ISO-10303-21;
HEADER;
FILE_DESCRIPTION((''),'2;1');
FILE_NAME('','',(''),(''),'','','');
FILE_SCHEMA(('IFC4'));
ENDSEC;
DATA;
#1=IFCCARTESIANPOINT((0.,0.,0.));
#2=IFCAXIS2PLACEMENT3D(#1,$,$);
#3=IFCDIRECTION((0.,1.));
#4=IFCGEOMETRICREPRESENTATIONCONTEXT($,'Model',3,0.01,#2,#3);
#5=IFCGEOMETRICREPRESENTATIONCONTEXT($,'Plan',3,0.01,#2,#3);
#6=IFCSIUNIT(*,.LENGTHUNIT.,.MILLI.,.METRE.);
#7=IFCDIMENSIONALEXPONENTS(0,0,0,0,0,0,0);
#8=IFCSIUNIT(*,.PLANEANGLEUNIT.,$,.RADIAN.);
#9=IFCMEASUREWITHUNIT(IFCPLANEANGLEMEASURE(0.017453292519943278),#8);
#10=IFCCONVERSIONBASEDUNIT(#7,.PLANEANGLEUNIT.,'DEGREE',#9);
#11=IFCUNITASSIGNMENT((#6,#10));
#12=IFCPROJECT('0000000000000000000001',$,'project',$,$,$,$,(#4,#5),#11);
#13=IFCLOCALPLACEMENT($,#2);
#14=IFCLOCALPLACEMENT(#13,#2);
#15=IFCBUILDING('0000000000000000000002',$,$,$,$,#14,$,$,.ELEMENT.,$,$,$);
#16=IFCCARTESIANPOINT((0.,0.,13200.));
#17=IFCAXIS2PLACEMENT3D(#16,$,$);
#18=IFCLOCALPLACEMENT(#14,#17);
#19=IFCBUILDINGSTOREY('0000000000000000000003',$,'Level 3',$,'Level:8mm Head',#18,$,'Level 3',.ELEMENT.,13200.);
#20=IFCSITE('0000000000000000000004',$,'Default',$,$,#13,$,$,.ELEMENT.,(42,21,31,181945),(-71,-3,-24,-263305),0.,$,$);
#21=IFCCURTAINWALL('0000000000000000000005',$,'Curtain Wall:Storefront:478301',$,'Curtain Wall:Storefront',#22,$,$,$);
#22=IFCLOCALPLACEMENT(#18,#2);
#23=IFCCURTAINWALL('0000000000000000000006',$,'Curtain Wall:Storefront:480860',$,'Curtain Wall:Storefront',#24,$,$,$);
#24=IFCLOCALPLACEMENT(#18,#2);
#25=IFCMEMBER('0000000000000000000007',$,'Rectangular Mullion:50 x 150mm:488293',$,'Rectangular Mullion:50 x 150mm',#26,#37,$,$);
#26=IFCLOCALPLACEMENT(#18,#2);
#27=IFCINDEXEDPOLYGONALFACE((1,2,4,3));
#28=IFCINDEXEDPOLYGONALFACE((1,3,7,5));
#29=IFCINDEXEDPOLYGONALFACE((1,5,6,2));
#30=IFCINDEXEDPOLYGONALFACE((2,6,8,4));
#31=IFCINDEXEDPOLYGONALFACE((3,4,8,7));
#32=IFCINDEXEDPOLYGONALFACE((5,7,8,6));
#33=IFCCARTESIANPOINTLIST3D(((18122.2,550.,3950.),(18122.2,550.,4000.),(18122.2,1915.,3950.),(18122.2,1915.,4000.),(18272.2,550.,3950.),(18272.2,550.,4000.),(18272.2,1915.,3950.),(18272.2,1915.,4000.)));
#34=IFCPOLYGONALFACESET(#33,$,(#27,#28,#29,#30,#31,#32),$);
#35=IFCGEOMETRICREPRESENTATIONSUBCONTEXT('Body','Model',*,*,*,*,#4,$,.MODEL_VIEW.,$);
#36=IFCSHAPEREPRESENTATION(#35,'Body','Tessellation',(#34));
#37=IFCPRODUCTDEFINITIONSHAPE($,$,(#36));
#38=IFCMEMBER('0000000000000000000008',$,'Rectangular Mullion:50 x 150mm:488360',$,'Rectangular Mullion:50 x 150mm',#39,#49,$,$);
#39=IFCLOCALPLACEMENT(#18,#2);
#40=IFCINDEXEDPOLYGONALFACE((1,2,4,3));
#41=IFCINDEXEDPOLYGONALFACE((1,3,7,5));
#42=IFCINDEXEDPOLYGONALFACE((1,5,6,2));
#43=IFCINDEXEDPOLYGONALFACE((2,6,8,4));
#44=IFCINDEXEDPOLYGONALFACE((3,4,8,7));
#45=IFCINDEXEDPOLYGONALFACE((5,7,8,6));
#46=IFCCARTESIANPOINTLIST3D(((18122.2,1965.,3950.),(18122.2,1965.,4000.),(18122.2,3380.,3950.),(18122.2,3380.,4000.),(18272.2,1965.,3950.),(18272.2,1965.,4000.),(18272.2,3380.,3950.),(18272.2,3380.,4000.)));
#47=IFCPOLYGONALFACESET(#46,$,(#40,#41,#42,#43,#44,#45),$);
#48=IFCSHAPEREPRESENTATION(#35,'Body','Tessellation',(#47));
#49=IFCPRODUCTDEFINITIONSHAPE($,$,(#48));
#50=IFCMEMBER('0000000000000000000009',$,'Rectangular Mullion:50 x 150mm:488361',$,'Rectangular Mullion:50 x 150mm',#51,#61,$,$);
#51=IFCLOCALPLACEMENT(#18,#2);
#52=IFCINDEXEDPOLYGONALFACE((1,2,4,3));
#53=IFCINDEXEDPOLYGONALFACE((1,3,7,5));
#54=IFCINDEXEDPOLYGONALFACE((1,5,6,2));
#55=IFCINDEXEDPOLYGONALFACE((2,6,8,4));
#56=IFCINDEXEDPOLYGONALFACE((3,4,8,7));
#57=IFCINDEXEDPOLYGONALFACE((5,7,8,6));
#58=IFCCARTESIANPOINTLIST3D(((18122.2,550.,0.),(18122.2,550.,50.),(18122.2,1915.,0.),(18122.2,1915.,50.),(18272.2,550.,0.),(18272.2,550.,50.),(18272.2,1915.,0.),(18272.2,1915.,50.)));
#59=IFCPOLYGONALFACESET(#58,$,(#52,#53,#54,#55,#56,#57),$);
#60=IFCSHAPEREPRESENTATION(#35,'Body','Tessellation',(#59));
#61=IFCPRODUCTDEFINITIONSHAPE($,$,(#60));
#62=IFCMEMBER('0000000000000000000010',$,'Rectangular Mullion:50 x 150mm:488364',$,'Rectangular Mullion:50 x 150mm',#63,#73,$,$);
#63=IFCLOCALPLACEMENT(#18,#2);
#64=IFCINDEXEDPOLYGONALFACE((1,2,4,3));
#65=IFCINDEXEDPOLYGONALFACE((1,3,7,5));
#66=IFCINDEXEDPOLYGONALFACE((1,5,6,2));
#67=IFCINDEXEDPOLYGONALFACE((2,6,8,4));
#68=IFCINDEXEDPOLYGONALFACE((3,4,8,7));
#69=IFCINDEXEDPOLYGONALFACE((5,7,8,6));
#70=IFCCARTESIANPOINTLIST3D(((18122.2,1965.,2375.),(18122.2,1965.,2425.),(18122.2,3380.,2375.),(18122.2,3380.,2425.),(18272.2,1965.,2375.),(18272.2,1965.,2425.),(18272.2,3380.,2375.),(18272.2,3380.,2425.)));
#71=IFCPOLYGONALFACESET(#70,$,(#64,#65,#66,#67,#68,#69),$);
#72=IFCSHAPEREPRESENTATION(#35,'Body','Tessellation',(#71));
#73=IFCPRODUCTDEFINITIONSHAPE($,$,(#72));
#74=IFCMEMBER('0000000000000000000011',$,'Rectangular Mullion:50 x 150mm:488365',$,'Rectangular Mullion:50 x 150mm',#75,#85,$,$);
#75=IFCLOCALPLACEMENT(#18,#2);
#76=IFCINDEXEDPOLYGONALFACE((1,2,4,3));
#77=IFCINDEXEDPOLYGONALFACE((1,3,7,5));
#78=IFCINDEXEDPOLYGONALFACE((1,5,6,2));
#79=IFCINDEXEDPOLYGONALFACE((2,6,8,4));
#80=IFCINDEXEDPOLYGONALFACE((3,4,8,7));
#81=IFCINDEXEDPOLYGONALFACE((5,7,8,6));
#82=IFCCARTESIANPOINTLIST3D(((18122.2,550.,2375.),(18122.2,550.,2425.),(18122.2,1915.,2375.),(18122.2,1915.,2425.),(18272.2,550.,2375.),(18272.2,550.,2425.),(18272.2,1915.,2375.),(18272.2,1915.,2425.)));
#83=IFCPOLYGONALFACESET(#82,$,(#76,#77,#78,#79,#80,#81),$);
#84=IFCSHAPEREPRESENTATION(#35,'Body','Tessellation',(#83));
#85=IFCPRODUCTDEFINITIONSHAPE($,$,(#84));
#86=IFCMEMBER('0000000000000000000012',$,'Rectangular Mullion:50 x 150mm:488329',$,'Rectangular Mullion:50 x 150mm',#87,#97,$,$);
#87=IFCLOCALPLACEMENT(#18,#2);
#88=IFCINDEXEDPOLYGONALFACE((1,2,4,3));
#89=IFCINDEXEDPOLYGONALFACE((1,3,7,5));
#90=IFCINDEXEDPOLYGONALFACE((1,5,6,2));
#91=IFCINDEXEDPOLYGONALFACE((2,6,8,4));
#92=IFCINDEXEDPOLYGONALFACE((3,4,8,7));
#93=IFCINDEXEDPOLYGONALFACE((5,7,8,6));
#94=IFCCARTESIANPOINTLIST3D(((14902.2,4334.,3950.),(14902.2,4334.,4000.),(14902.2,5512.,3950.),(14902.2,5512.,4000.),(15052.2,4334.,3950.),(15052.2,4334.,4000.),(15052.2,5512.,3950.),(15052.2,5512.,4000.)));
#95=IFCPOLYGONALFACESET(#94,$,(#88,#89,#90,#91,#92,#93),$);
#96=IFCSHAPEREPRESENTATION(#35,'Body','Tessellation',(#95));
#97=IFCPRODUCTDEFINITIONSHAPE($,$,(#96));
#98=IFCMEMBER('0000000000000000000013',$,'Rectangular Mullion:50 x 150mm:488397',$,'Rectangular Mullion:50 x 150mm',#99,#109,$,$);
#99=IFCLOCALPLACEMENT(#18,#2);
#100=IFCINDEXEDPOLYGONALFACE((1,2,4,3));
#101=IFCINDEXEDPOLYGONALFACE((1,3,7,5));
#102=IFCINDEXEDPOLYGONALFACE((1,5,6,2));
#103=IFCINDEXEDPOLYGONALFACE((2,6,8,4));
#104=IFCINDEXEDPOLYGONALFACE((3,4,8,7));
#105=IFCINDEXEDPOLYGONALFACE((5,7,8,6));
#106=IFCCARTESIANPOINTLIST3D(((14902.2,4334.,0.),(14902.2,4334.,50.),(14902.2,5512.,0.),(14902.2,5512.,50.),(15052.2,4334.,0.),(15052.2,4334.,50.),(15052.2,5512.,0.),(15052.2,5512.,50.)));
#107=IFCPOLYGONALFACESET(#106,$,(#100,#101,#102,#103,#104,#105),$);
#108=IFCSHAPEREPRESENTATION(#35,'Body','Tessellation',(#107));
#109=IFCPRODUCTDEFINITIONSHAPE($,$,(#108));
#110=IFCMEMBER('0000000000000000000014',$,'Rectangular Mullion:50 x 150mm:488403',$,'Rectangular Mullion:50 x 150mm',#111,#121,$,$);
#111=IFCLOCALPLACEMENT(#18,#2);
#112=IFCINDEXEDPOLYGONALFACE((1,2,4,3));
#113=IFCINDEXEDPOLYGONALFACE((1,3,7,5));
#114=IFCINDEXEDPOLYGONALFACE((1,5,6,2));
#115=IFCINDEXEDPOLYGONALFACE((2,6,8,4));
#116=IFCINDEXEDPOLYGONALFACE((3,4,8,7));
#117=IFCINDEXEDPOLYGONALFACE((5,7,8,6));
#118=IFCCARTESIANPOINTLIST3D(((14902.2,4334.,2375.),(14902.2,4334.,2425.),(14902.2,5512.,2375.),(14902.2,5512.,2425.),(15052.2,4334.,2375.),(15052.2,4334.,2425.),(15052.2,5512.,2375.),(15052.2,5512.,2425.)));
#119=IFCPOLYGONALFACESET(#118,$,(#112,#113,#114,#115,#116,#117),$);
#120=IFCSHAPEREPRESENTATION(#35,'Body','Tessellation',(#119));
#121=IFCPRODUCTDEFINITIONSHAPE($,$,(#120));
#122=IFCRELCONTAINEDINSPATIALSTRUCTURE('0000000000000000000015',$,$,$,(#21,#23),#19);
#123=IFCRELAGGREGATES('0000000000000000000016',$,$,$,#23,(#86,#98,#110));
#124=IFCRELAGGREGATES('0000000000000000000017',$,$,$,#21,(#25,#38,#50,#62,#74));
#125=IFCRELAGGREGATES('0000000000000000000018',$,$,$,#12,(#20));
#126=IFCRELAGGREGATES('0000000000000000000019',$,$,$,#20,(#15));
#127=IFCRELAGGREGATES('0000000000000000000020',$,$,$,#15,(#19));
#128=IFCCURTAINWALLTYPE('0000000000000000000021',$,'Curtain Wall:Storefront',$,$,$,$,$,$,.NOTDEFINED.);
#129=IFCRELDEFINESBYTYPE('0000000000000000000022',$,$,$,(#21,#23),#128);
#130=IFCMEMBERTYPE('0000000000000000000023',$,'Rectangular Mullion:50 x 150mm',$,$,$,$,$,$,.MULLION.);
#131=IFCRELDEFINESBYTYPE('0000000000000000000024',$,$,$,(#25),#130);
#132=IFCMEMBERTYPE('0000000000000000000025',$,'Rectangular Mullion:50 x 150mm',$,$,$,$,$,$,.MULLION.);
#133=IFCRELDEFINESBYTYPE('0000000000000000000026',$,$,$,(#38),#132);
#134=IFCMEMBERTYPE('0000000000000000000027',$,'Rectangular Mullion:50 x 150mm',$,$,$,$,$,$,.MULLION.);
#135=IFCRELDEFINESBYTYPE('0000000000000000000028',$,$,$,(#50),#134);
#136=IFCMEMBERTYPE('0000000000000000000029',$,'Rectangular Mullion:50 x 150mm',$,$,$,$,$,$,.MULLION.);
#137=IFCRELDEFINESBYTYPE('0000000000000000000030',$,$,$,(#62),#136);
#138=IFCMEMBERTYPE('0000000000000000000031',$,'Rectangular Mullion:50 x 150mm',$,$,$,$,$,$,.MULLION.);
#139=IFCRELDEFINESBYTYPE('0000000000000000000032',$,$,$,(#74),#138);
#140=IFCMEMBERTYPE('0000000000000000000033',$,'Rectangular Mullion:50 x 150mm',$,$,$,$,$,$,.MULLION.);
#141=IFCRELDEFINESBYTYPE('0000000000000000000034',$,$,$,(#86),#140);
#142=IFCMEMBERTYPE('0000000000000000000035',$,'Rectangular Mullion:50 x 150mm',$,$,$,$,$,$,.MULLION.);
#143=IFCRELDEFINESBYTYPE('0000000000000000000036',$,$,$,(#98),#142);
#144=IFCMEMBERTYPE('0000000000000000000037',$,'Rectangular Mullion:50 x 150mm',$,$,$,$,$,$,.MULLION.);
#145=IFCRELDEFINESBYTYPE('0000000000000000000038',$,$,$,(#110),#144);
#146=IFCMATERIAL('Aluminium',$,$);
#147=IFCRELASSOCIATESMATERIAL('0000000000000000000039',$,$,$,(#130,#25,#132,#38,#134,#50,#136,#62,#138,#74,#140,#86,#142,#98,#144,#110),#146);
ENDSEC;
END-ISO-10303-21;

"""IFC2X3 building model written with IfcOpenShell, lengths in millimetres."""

from ifc_helpers import new_model, entity, si_unit, converted_unit, direction, frame, origin, origin_2d_with_axis, place, context, subcontext, project, spatial, rectangle, extrude, source, transform, mapped, material, type_object, type_shapes, element, aggregate, save


model = new_model("IFC2X3")

# Units and contexts
model_context = context("Model", 3, precision=0.01, world=origin(), true_north=direction((0.0, 1.0)))
plan_context = context("Plan", 3, precision=0.01, world=origin(), true_north=direction((0.0, 1.0)))
body_context = subcontext(model_context, "Body", "Model", "MODEL_VIEW")
ifc_project = project(units=[si_unit("LENGTHUNIT", "METRE", prefix="MILLI"), converted_unit("PLANEANGLEUNIT", "DEGREE", entity("IfcPlaneAngleMeasure", 0.017453292519943278), si_unit("PLANEANGLEUNIT", "RADIAN"), dimensions=[0, 0, 0, 0, 0, 0, 0])], contexts=[model_context, plan_context])

# Site, building, storey
site_placement = place(None, origin())
site = spatial("IfcSite", under=ifc_project, at=site_placement, Name="Default", CompositionType="ELEMENT", RefLatitude=(42, 21, 31, 181945), RefLongitude=(-71, -3, -24, -263305), RefElevation=0.0)
building_placement = place(site_placement, origin())
building = spatial("IfcBuilding", under=site, at=building_placement, CompositionType="ELEMENT")
storey_placement = place(building_placement, frame((0.0, 0.0, 13200.0)))
storey = spatial("IfcBuildingStorey", under=building, at=storey_placement, Name="Level 3", ObjectType="Level:8mm Head", LongName="Level 3", CompositionType="ELEMENT", Elevation=13200.0)

# Curtain walls
curtain_wall_type = type_object("IfcCurtainWallType", Name="Curtain Wall:Storefront", PredefinedType="NOTDEFINED")
curtain_wall_1_placement = place(storey_placement, frame((0.0, 0.0, -13200.0)))
curtain_wall_1 = element("IfcCurtainWall", 1, at=curtain_wall_1_placement, inside=storey, type_object=curtain_wall_type, Name="Curtain Wall:Storefront:478301", ObjectType="Curtain Wall:Storefront")
ifc_material_1 = material(Name="Aluminium")
curtain_wall_2_placement = place(storey_placement, frame((0.0, 0.0, -13200.0)))
curtain_wall_2 = element("IfcCurtainWall", 2, at=curtain_wall_2_placement, inside=storey, type_object=curtain_wall_type, Name="Curtain Wall:Storefront:480860", ObjectType="Curtain Wall:Storefront")

# Members
member_type_1 = type_object("IfcMemberType", Name="Rectangular Mullion:50 x 150mm", PredefinedType="MULLION", material=ifc_material_1)
shared_shape_1 = source(origin(), body_context, "Body", "SweptSolid", [
    extrude(rectangle(XDim=50.0, YDim=150.0, at=origin_2d_with_axis()), frame((-25.0, 0.0, -1365.0), z_axis=(0.0, 0.0, 1.0), x_axis=(-1.0, 0.0, 0.0)), (0.0, 0.0, 1.0), 1365.0),
])
type_shapes(member_type_1, [shared_shape_1])
member_1_placement = place(curtain_wall_1_placement, frame((18197.2, 550.0, 17200.0), z_axis=(0.0, -1.0, 0.0), x_axis=(0.0, 0.0, 1.0)))
member_1 = element("IfcMember", 3, at=member_1_placement, type_object=member_type_1, material=ifc_material_1, Name="Rectangular Mullion:50 x 150mm:488293", ObjectType="Rectangular Mullion:50 x 150mm", context=body_context, shape_type="MappedRepresentation", body=[
    mapped(shared_shape_1, transform((0.0, 0.0, 0.0), scale=1.0)),
])
member_type_2 = type_object("IfcMemberType", Name="Rectangular Mullion:50 x 150mm", PredefinedType="MULLION", material=ifc_material_1)
shared_shape_2 = source(origin(), body_context, "Body", "SweptSolid", [
    extrude(rectangle(XDim=50.0, YDim=150.0, at=origin_2d_with_axis()), frame((-25.0, 0.0, -1415.0), z_axis=(0.0, 0.0, 1.0), x_axis=(-1.0, 0.0, 0.0)), (0.0, 0.0, 1.0), 1415.0),
])
type_shapes(member_type_2, [shared_shape_2])
member_2_placement = place(curtain_wall_1_placement, frame((18197.2, 1965.0, 17200.0), z_axis=(0.0, -1.0, 0.0), x_axis=(0.0, 0.0, 1.0)))
member_2 = element("IfcMember", 4, at=member_2_placement, type_object=member_type_2, material=ifc_material_1, Name="Rectangular Mullion:50 x 150mm:488360", ObjectType="Rectangular Mullion:50 x 150mm", context=body_context, shape_type="MappedRepresentation", body=[
    mapped(shared_shape_2, transform((0.0, 0.0, 0.0), scale=1.0)),
])
member_type_3 = type_object("IfcMemberType", Name="Rectangular Mullion:50 x 150mm", PredefinedType="MULLION", material=ifc_material_1)
shared_shape_3 = source(origin(), body_context, "Body", "SweptSolid", [
    extrude(rectangle(XDim=50.0, YDim=150.0, at=origin_2d_with_axis()), frame((-25.0, 0.0, -1365.0), z_axis=(0.0, 0.0, 1.0), x_axis=(-1.0, 0.0, 0.0)), (0.0, 0.0, 1.0), 1365.0),
])
type_shapes(member_type_3, [shared_shape_3])
member_3_placement = place(curtain_wall_1_placement, frame((18197.2, 1915.0, 13200.0), z_axis=(0.0, 1.0, 0.0), x_axis=(0.0, 0.0, -1.0)))
member_3 = element("IfcMember", 5, at=member_3_placement, type_object=member_type_3, material=ifc_material_1, Name="Rectangular Mullion:50 x 150mm:488361", ObjectType="Rectangular Mullion:50 x 150mm", context=body_context, shape_type="MappedRepresentation", body=[
    mapped(shared_shape_3, transform((0.0, 0.0, 0.0), scale=1.0)),
])
member_type_4 = type_object("IfcMemberType", Name="Rectangular Mullion:50 x 150mm", PredefinedType="MULLION", material=ifc_material_1)
shared_shape_4 = source(origin(), body_context, "Body", "SweptSolid", [
    extrude(rectangle(XDim=50.0, YDim=150.0, at=origin_2d_with_axis()), frame((0.0, 0.0, -1415.0), z_axis=(0.0, 0.0, 1.0), x_axis=(-1.0, 0.0, 0.0)), (0.0, 0.0, 1.0), 1415.0),
])
type_shapes(member_type_4, [shared_shape_4])
member_4_placement = place(curtain_wall_1_placement, frame((18197.2, 1965.0, 15600.0), z_axis=(0.0, -1.0, 0.0), x_axis=(0.0, 0.0, 1.0)))
member_4 = element("IfcMember", 6, at=member_4_placement, type_object=member_type_4, material=ifc_material_1, Name="Rectangular Mullion:50 x 150mm:488364", ObjectType="Rectangular Mullion:50 x 150mm", context=body_context, shape_type="MappedRepresentation", body=[
    mapped(shared_shape_4, transform((0.0, 0.0, 0.0), scale=1.0)),
])
member_type_5 = type_object("IfcMemberType", Name="Rectangular Mullion:50 x 150mm", PredefinedType="MULLION", material=ifc_material_1)
shared_shape_5 = source(origin(), body_context, "Body", "SweptSolid", [
    extrude(rectangle(XDim=50.0, YDim=150.0, at=origin_2d_with_axis()), frame((0.0, 0.0, -1365.0), z_axis=(0.0, 0.0, 1.0), x_axis=(-1.0, 0.0, 0.0)), (0.0, 0.0, 1.0), 1365.0),
])
type_shapes(member_type_5, [shared_shape_5])
member_5_placement = place(curtain_wall_1_placement, frame((18197.2, 550.0, 15600.0), z_axis=(0.0, -1.0, 0.0), x_axis=(0.0, 0.0, 1.0)))
member_5 = element("IfcMember", 7, at=member_5_placement, type_object=member_type_5, material=ifc_material_1, Name="Rectangular Mullion:50 x 150mm:488365", ObjectType="Rectangular Mullion:50 x 150mm", context=body_context, shape_type="MappedRepresentation", body=[
    mapped(shared_shape_5, transform((0.0, 0.0, 0.0), scale=1.0)),
])
member_type_6 = type_object("IfcMemberType", Name="Rectangular Mullion:50 x 150mm", PredefinedType="MULLION", material=ifc_material_1)
shared_shape_6 = source(origin(), body_context, "Body", "SweptSolid", [
    extrude(rectangle(XDim=50.0, YDim=150.0, at=origin_2d_with_axis()), frame((-25.0, 0.0, -1178.0), z_axis=(0.0, 0.0, 1.0), x_axis=(-1.0, 0.0, 0.0)), (0.0, 0.0, 1.0), 1178.0),
])
type_shapes(member_type_6, [shared_shape_6])
member_6_placement = place(curtain_wall_2_placement, frame((14977.2, 5512.0, 17200.0), z_axis=(0.0, 1.0, 0.0), x_axis=(0.0, 0.0, 1.0)))
member_6 = element("IfcMember", 8, at=member_6_placement, type_object=member_type_6, material=ifc_material_1, Name="Rectangular Mullion:50 x 150mm:488329", ObjectType="Rectangular Mullion:50 x 150mm", context=body_context, shape_type="MappedRepresentation", body=[
    mapped(shared_shape_6, transform((0.0, 0.0, 0.0), scale=1.0)),
])
member_type_7 = type_object("IfcMemberType", Name="Rectangular Mullion:50 x 150mm", PredefinedType="MULLION", material=ifc_material_1)
shared_shape_7 = source(origin(), body_context, "Body", "SweptSolid", [
    extrude(rectangle(XDim=50.0, YDim=150.0, at=origin_2d_with_axis()), frame((-25.0, 0.0, -1178.0), z_axis=(0.0, 0.0, 1.0), x_axis=(-1.0, 0.0, 0.0)), (0.0, 0.0, 1.0), 1178.0),
])
type_shapes(member_type_7, [shared_shape_7])
member_7_placement = place(curtain_wall_2_placement, frame((14977.2, 4334.0, 13200.0), z_axis=(0.0, -1.0, 0.0), x_axis=(0.0, 0.0, -1.0)))
member_7 = element("IfcMember", 9, at=member_7_placement, type_object=member_type_7, material=ifc_material_1, Name="Rectangular Mullion:50 x 150mm:488397", ObjectType="Rectangular Mullion:50 x 150mm", context=body_context, shape_type="MappedRepresentation", body=[
    mapped(shared_shape_7, transform((0.0, 0.0, 0.0), scale=1.0)),
])
member_type_8 = type_object("IfcMemberType", Name="Rectangular Mullion:50 x 150mm", PredefinedType="MULLION", material=ifc_material_1)
shared_shape_8 = source(origin(), body_context, "Body", "SweptSolid", [
    extrude(rectangle(XDim=50.0, YDim=150.0, at=origin_2d_with_axis()), frame((0.0, 0.0, -1178.0), z_axis=(0.0, 0.0, 1.0), x_axis=(-1.0, 0.0, 0.0)), (0.0, 0.0, 1.0), 1178.0),
])
type_shapes(member_type_8, [shared_shape_8])
member_8_placement = place(curtain_wall_2_placement, frame((14977.2, 5512.0, 15600.0), z_axis=(0.0, 1.0, 0.0), x_axis=(0.0, 0.0, 1.0)))
member_8 = element("IfcMember", 10, at=member_8_placement, type_object=member_type_8, material=ifc_material_1, Name="Rectangular Mullion:50 x 150mm:488403", ObjectType="Rectangular Mullion:50 x 150mm", context=body_context, shape_type="MappedRepresentation", body=[
    mapped(shared_shape_8, transform((0.0, 0.0, 0.0), scale=1.0)),
])

aggregate(curtain_wall_2, [member_6, member_7, member_8])

aggregate(curtain_wall_1, [member_1, member_2, member_3, member_4, member_5])

save(model, "model.ifc")
